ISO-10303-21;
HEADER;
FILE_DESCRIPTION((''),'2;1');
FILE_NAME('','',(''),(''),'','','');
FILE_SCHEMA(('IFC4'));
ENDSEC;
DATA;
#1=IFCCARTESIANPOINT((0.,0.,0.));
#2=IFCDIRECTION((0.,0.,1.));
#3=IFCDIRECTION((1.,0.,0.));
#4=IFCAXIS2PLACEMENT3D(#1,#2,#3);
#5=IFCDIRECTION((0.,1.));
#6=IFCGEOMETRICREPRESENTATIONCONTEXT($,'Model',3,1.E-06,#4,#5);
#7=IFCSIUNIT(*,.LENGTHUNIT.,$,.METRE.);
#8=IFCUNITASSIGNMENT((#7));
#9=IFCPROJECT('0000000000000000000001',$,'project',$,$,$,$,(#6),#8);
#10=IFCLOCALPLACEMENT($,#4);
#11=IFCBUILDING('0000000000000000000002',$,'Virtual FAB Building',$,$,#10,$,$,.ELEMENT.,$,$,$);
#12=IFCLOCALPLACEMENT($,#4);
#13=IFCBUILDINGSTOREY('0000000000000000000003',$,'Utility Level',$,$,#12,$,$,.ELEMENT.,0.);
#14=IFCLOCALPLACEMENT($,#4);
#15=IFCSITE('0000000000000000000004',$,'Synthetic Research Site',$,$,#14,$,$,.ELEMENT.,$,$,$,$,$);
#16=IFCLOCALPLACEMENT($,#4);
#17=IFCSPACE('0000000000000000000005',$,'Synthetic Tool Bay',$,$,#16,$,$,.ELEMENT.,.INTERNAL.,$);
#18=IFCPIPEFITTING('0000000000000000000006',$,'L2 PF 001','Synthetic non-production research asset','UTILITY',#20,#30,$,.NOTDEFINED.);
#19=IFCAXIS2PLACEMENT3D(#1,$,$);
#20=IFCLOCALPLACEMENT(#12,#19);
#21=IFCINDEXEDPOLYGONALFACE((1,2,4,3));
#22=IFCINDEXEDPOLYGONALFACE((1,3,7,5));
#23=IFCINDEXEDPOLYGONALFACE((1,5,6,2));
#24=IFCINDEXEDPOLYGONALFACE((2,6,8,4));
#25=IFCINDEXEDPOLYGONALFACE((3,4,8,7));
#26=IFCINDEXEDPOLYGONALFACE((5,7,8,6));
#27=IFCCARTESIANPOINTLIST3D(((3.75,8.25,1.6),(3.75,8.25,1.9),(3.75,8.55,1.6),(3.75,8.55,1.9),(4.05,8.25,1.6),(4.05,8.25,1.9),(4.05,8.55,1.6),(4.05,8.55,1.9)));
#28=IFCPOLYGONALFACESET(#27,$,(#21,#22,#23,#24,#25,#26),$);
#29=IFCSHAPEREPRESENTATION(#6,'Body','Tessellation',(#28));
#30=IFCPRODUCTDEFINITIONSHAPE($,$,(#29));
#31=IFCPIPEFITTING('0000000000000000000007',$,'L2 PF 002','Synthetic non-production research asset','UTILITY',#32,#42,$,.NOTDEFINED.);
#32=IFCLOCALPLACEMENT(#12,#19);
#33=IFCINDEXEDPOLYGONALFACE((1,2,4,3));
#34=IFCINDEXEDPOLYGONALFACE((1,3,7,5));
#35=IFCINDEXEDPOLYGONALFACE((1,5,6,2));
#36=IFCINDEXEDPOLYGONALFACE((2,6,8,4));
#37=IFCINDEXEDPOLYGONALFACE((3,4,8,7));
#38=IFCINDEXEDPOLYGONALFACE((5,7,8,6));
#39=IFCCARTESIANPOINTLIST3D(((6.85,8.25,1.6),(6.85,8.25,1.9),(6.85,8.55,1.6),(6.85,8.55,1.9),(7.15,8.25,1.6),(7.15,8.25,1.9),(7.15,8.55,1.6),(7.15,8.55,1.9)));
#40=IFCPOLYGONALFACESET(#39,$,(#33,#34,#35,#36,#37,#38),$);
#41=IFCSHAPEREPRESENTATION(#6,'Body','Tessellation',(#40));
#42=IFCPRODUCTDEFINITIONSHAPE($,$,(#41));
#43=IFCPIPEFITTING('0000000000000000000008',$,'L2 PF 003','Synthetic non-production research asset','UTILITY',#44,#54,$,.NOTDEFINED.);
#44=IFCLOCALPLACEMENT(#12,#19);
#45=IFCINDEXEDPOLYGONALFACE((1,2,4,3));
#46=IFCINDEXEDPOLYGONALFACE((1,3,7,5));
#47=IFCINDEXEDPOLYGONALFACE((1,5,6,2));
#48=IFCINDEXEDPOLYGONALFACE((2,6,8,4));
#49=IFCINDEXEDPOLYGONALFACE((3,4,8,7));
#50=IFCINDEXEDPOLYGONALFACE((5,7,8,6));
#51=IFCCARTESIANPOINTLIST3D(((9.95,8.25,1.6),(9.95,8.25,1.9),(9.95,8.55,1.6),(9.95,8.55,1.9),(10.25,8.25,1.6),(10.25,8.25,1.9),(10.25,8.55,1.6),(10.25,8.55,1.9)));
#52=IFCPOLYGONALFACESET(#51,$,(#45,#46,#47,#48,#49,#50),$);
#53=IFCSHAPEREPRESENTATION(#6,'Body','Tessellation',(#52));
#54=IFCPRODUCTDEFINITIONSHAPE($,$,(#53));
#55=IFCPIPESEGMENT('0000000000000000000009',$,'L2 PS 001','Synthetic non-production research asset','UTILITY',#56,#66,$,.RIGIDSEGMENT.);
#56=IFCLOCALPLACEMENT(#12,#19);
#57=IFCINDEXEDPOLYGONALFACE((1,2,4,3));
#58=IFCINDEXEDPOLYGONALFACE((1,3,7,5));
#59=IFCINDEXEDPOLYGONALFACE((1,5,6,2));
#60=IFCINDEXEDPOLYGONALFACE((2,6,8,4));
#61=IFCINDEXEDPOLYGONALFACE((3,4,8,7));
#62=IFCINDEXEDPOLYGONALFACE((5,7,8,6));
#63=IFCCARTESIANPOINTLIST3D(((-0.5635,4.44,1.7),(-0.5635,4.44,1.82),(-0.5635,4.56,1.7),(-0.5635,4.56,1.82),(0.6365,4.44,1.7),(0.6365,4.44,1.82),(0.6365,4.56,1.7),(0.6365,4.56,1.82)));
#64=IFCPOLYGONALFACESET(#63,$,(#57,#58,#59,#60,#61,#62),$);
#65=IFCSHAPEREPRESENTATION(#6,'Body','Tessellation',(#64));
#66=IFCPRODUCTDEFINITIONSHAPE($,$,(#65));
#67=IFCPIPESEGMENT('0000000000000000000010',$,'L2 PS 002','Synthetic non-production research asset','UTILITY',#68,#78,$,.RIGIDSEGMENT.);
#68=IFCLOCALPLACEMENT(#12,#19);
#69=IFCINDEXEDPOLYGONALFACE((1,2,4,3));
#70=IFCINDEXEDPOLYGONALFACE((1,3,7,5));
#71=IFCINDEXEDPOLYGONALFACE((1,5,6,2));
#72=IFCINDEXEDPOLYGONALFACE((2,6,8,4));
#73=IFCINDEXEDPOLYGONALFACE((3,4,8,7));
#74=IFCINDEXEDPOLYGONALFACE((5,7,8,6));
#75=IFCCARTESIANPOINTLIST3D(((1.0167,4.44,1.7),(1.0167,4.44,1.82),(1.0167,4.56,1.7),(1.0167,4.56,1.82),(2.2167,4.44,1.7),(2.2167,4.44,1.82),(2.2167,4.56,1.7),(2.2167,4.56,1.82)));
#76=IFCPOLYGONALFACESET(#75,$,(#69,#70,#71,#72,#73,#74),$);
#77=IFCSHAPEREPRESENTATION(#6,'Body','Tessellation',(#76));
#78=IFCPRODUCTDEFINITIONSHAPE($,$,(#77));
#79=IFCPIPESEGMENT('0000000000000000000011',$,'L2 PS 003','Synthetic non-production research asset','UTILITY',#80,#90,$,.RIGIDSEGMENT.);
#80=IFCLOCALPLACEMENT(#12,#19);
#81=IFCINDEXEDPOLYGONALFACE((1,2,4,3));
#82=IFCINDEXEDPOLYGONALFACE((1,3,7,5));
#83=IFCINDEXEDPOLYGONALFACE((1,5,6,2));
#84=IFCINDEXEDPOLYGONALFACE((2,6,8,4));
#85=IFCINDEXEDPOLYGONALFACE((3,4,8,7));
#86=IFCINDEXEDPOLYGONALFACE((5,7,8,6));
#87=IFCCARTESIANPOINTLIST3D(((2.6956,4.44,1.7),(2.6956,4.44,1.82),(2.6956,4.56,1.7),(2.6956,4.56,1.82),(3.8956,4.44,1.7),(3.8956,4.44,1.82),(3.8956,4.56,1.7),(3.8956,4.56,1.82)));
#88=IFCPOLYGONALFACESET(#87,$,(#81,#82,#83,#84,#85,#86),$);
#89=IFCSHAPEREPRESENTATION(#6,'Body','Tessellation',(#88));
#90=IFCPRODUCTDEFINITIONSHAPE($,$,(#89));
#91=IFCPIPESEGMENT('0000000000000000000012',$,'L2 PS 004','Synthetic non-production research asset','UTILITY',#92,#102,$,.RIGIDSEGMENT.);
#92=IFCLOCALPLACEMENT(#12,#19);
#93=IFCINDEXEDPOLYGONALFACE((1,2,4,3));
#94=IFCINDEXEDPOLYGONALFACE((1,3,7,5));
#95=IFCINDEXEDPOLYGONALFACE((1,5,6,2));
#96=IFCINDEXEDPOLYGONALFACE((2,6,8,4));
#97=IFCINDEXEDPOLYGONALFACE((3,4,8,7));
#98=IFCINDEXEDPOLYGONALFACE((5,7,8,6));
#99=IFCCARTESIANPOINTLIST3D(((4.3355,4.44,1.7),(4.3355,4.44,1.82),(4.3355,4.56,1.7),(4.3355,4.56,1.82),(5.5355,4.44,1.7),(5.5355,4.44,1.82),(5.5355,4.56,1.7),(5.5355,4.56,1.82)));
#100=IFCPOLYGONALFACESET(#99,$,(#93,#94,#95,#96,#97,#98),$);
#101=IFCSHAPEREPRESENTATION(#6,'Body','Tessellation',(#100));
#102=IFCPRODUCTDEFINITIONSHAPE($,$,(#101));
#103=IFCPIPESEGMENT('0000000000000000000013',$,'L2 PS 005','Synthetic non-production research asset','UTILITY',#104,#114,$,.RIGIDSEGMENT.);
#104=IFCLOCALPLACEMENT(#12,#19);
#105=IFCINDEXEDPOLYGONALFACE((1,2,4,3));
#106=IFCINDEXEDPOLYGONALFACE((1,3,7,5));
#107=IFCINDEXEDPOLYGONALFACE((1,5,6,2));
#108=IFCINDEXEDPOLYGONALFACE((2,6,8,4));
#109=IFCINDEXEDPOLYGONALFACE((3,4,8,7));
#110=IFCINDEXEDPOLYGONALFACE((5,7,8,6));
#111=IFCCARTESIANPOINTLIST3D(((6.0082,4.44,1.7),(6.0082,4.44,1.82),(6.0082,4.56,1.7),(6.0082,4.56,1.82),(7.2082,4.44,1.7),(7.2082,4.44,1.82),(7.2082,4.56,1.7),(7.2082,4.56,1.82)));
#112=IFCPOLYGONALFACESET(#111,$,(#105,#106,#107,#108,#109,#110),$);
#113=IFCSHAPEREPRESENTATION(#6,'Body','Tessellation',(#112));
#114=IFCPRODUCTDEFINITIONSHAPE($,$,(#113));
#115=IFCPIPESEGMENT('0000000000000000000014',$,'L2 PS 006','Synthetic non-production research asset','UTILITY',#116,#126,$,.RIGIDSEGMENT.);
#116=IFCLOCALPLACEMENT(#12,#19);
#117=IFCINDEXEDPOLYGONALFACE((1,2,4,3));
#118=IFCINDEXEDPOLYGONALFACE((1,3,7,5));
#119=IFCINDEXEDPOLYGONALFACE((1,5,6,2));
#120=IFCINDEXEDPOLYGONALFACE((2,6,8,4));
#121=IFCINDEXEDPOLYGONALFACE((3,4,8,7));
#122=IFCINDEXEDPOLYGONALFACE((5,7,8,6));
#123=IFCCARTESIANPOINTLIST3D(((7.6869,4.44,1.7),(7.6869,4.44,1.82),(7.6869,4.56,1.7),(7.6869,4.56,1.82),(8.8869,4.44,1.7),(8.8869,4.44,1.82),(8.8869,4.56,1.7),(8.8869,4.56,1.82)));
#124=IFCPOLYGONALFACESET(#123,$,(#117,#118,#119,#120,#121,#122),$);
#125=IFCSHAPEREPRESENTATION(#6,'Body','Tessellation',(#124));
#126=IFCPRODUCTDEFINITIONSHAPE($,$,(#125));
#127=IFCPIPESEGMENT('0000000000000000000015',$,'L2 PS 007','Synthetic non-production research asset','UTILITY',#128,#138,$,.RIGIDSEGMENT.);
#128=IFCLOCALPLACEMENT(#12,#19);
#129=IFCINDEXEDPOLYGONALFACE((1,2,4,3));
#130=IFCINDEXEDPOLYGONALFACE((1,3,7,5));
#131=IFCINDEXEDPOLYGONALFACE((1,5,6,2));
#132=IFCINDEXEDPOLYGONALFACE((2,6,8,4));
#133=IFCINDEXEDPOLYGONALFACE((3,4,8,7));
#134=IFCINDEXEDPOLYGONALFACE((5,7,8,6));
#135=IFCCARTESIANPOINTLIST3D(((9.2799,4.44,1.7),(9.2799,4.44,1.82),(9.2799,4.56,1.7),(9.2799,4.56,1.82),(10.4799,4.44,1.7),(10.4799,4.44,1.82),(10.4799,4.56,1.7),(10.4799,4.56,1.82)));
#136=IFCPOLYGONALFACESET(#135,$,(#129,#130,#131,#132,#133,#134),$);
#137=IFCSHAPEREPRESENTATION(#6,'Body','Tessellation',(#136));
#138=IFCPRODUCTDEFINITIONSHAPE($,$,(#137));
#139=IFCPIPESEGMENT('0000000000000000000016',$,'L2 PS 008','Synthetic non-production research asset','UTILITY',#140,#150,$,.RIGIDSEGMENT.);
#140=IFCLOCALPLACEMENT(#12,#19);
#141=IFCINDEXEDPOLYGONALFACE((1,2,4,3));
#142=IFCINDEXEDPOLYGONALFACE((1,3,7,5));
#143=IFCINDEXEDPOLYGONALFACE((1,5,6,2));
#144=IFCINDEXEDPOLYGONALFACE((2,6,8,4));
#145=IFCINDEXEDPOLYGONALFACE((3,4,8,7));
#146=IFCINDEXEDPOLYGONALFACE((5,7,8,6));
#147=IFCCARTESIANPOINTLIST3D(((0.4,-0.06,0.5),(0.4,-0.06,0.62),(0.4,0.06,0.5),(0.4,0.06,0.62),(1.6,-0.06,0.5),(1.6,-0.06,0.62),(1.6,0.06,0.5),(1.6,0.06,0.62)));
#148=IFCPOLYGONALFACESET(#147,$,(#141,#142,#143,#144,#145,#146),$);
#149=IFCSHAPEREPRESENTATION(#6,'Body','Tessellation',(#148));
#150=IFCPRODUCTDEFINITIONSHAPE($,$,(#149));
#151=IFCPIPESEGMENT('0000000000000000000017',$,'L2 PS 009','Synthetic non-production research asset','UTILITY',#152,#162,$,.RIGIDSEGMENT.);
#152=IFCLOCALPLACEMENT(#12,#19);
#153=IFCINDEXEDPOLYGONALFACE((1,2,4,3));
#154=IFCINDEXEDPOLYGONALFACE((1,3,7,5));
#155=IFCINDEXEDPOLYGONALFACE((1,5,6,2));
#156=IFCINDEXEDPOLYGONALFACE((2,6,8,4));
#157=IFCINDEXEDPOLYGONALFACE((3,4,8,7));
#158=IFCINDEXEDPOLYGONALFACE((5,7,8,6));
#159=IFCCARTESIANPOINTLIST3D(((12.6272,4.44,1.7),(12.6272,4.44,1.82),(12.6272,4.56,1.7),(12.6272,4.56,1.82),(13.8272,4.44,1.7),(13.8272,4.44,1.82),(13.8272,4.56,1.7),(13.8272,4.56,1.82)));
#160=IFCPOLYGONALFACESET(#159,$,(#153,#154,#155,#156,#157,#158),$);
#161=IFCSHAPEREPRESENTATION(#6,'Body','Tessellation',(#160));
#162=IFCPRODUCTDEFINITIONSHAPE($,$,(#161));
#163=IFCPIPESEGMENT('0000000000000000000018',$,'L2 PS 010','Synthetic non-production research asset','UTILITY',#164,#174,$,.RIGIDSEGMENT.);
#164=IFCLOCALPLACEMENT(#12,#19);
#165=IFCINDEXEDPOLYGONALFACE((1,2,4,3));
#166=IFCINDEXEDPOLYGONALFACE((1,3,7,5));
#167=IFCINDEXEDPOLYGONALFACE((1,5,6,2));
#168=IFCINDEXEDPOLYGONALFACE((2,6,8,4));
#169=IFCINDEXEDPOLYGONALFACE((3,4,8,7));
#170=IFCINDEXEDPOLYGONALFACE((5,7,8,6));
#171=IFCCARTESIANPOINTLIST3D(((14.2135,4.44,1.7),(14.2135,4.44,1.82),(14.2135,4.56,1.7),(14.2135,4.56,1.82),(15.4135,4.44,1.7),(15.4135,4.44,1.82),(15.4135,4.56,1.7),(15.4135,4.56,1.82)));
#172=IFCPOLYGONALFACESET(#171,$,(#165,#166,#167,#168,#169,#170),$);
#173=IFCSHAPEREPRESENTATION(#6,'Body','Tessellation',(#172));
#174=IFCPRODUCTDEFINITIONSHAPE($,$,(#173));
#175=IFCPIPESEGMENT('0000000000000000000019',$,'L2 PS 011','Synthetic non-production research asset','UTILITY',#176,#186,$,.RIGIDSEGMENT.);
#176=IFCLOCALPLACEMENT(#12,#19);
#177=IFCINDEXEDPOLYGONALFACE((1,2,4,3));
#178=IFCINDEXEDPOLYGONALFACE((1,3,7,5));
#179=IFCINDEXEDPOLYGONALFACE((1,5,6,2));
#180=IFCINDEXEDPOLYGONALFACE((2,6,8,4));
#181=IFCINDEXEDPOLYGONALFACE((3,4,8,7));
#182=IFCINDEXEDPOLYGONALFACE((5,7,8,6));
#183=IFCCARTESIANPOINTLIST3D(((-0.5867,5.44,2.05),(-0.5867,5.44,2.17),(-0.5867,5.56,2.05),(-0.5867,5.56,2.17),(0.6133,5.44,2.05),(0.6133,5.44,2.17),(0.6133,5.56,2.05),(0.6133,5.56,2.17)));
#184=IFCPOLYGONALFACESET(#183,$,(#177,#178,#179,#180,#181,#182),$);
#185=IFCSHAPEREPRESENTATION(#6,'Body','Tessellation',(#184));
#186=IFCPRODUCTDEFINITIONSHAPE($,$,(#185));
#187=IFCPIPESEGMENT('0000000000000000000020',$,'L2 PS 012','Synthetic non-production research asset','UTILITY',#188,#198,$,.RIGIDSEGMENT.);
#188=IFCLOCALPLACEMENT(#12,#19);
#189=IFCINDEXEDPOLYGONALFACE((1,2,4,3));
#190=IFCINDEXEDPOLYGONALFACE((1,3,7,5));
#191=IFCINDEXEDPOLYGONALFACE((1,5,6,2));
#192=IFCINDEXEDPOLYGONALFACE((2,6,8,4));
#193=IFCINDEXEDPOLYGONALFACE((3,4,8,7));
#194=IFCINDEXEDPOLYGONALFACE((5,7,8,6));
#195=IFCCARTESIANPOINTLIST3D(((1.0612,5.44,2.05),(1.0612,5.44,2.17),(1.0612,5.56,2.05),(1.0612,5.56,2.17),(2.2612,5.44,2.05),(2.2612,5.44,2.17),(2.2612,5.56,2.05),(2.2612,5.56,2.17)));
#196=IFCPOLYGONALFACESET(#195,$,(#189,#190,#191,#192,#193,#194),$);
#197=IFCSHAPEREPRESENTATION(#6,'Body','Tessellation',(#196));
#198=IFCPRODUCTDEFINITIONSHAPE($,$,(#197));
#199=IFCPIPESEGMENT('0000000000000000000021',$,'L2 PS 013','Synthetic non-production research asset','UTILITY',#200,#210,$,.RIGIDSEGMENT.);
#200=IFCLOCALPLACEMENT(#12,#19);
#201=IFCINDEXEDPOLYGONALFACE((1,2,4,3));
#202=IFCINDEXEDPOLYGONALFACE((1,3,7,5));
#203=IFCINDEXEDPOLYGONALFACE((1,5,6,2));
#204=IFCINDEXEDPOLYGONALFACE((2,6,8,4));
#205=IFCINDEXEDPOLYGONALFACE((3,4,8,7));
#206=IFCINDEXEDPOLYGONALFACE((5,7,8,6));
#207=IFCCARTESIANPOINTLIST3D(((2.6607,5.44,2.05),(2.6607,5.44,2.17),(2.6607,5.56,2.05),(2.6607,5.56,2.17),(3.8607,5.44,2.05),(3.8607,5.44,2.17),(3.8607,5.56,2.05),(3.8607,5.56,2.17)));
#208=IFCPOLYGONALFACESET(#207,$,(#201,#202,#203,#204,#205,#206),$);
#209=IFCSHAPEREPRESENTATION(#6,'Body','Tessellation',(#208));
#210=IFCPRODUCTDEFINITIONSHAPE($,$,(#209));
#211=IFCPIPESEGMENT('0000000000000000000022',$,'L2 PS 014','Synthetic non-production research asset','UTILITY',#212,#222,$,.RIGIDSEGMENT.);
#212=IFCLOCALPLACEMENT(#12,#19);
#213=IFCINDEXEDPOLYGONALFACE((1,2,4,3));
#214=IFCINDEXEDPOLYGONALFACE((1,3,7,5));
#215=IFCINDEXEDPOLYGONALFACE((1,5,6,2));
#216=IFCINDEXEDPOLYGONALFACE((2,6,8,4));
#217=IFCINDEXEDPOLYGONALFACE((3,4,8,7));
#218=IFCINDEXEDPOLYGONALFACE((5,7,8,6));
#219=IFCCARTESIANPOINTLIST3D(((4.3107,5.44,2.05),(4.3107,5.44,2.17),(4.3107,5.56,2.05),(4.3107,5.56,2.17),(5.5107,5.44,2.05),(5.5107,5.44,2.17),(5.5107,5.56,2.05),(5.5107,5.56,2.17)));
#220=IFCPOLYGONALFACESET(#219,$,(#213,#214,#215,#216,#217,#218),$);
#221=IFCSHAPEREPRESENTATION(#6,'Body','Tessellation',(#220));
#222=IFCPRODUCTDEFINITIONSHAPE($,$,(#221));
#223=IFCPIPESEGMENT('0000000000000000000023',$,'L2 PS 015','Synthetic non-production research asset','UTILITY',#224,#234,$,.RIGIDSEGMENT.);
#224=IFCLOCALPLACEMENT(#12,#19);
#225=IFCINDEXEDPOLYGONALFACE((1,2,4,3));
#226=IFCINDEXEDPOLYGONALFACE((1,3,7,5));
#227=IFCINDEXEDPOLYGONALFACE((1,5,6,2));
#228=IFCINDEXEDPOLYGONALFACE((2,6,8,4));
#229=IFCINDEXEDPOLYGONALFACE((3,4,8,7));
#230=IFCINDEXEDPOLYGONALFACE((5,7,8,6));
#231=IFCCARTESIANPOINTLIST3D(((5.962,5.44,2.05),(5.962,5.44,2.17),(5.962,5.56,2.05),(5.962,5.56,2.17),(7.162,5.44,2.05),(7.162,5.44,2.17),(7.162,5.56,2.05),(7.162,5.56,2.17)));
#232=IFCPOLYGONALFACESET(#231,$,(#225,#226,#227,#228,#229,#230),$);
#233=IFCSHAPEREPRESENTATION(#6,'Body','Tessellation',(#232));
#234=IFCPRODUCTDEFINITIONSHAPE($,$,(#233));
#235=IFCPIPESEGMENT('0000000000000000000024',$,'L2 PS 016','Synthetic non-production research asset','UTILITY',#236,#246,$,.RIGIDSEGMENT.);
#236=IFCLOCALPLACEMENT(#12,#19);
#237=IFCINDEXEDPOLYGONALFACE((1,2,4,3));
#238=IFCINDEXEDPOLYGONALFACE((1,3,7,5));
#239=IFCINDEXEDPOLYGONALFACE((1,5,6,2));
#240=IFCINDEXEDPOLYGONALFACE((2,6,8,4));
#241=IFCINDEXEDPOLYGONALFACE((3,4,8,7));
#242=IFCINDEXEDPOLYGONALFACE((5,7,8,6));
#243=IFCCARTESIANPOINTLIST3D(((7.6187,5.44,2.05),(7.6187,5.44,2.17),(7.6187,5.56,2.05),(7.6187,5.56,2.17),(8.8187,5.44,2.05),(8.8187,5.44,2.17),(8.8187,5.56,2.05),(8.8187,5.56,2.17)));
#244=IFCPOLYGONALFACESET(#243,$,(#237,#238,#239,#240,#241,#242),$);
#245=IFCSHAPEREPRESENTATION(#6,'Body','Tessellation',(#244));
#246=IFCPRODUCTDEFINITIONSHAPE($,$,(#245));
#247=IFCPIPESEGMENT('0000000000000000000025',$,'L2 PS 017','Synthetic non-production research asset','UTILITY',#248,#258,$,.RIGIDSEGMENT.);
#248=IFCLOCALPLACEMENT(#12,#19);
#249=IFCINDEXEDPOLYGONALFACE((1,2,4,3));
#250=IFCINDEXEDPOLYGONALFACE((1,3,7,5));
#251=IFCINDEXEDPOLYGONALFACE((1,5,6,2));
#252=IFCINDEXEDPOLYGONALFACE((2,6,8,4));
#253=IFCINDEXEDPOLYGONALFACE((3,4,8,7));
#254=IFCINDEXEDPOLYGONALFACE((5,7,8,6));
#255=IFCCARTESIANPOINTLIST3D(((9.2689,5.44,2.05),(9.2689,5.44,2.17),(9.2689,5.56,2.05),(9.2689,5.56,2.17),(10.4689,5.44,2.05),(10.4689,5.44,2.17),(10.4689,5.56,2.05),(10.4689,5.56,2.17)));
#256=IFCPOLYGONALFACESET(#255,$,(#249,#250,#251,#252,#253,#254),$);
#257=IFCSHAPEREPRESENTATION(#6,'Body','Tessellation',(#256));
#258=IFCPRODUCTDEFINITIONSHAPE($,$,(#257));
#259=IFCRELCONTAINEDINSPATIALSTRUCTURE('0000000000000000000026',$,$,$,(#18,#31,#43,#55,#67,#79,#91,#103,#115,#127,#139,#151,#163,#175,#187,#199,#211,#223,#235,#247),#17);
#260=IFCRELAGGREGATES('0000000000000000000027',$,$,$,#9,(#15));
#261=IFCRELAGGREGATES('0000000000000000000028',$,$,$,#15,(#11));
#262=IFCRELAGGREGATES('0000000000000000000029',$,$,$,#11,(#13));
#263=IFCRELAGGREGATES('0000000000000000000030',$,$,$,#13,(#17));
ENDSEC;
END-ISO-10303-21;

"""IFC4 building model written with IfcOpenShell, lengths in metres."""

from ifc_helpers import new_model, si_unit, direction, frame, origin_with_axes, origin_2d_with_axis, place, context, project, spatial, rectangle, extrude, element, save


model = new_model("IFC4")

# Units and contexts
model_context = context("Model", 3, precision=1e-06, world=origin_with_axes(), true_north=direction((0.0, 1.0)))
ifc_project = project(units=[si_unit("LENGTHUNIT", "METRE")], contexts=[model_context])

# Site, building, storey, space
site_placement = place(None, origin_with_axes())
site = spatial("IfcSite", under=ifc_project, at=site_placement, Name="Synthetic Research Site", CompositionType="ELEMENT")
building_placement = place(None, origin_with_axes())
building = spatial("IfcBuilding", under=site, at=building_placement, Name="Virtual FAB Building", CompositionType="ELEMENT")
storey_placement = place(None, origin_with_axes())
storey = spatial("IfcBuildingStorey", under=building, at=storey_placement, Name="Utility Level", CompositionType="ELEMENT", Elevation=0.0)
space_placement = place(None, origin_with_axes())
space = spatial("IfcSpace", under=storey, at=space_placement, Name="Synthetic Tool Bay", CompositionType="ELEMENT", PredefinedType="INTERNAL")

# Pipe fittings
for number, where, z_axis, x_axis, name in (
    (1, (3.9, 8.4, 1.6), (0.0, 0.0, 1.0), (1.0, 0.0, 0.0), "L2 PF 001"),
    (2, (7.0, 8.4, 1.6), (0.0, 0.0, 1.0), (1.0, 0.0, 0.0), "L2 PF 002"),
    (3, (10.1, 8.4, 1.6), (0.0, 0.0, 1.0), (1.0, 0.0, 0.0), "L2 PF 003"),
):
    element("IfcPipeFitting", number, at=place(None, frame(where, z_axis=z_axis, x_axis=x_axis)), inside=space, Name=name, Description="Synthetic non-production research asset", ObjectType="UTILITY", PredefinedType="NOTDEFINED", context=model_context, shape_type="SweptSolid", body=[
        extrude(rectangle(XDim=0.3, YDim=0.3, at=origin_2d_with_axis()), origin_with_axes(), (0.0, 0.0, 1.0), 0.3),
    ])

# Pipe segments
for number, where, z_axis, x_axis, name in (
    (4, (0.0365, 4.5, 1.7), (0.0, 0.0, 1.0), (1.0, 0.0, 0.0), "L2 PS 001"),
    (5, (1.6167, 4.5, 1.7), (0.0, 0.0, 1.0), (1.0, 0.0, 0.0), "L2 PS 002"),
    (6, (3.2956, 4.5, 1.7), (0.0, 0.0, 1.0), (1.0, 0.0, 0.0), "L2 PS 003"),
    (7, (4.9355, 4.5, 1.7), (0.0, 0.0, 1.0), (1.0, 0.0, 0.0), "L2 PS 004"),
    (8, (6.6082, 4.5, 1.7), (0.0, 0.0, 1.0), (1.0, 0.0, 0.0), "L2 PS 005"),
    (9, (8.2869, 4.5, 1.7), (0.0, 0.0, 1.0), (1.0, 0.0, 0.0), "L2 PS 006"),
    (10, (9.8799, 4.5, 1.7), (0.0, 0.0, 1.0), (1.0, 0.0, 0.0), "L2 PS 007"),
    (11, (1.0, 0.0, 0.5), (0.0, 0.0, 1.0), (1.0, 0.0, 0.0), "L2 PS 008"),
    (12, (13.2272, 4.5, 1.7), (0.0, 0.0, 1.0), (1.0, 0.0, 0.0), "L2 PS 009"),
    (13, (14.8135, 4.5, 1.7), (0.0, 0.0, 1.0), (1.0, 0.0, 0.0), "L2 PS 010"),
    (14, (0.0133, 5.5, 2.05), (0.0, 0.0, 1.0), (1.0, 0.0, 0.0), "L2 PS 011"),
    (15, (1.6612, 5.5, 2.05), (0.0, 0.0, 1.0), (1.0, 0.0, 0.0), "L2 PS 012"),
    (16, (3.2607, 5.5, 2.05), (0.0, 0.0, 1.0), (1.0, 0.0, 0.0), "L2 PS 013"),
    (17, (4.9107, 5.5, 2.05), (0.0, 0.0, 1.0), (1.0, 0.0, 0.0), "L2 PS 014"),
    (18, (6.562, 5.5, 2.05), (0.0, 0.0, 1.0), (1.0, 0.0, 0.0), "L2 PS 015"),
    (19, (8.2187, 5.5, 2.05), (0.0, 0.0, 1.0), (1.0, 0.0, 0.0), "L2 PS 016"),
    (20, (9.8689, 5.5, 2.05), (0.0, 0.0, 1.0), (1.0, 0.0, 0.0), "L2 PS 017"),
):
    element("IfcPipeSegment", number, at=place(None, frame(where, z_axis=z_axis, x_axis=x_axis)), inside=space, Name=name, Description="Synthetic non-production research asset", ObjectType="UTILITY", PredefinedType="RIGIDSEGMENT", context=model_context, shape_type="SweptSolid", body=[
        extrude(rectangle(XDim=1.2, YDim=0.12, at=origin_2d_with_axis()), origin_with_axes(), (0.0, 0.0, 1.0), 0.12),
    ])

save(model, "model.ifc")
